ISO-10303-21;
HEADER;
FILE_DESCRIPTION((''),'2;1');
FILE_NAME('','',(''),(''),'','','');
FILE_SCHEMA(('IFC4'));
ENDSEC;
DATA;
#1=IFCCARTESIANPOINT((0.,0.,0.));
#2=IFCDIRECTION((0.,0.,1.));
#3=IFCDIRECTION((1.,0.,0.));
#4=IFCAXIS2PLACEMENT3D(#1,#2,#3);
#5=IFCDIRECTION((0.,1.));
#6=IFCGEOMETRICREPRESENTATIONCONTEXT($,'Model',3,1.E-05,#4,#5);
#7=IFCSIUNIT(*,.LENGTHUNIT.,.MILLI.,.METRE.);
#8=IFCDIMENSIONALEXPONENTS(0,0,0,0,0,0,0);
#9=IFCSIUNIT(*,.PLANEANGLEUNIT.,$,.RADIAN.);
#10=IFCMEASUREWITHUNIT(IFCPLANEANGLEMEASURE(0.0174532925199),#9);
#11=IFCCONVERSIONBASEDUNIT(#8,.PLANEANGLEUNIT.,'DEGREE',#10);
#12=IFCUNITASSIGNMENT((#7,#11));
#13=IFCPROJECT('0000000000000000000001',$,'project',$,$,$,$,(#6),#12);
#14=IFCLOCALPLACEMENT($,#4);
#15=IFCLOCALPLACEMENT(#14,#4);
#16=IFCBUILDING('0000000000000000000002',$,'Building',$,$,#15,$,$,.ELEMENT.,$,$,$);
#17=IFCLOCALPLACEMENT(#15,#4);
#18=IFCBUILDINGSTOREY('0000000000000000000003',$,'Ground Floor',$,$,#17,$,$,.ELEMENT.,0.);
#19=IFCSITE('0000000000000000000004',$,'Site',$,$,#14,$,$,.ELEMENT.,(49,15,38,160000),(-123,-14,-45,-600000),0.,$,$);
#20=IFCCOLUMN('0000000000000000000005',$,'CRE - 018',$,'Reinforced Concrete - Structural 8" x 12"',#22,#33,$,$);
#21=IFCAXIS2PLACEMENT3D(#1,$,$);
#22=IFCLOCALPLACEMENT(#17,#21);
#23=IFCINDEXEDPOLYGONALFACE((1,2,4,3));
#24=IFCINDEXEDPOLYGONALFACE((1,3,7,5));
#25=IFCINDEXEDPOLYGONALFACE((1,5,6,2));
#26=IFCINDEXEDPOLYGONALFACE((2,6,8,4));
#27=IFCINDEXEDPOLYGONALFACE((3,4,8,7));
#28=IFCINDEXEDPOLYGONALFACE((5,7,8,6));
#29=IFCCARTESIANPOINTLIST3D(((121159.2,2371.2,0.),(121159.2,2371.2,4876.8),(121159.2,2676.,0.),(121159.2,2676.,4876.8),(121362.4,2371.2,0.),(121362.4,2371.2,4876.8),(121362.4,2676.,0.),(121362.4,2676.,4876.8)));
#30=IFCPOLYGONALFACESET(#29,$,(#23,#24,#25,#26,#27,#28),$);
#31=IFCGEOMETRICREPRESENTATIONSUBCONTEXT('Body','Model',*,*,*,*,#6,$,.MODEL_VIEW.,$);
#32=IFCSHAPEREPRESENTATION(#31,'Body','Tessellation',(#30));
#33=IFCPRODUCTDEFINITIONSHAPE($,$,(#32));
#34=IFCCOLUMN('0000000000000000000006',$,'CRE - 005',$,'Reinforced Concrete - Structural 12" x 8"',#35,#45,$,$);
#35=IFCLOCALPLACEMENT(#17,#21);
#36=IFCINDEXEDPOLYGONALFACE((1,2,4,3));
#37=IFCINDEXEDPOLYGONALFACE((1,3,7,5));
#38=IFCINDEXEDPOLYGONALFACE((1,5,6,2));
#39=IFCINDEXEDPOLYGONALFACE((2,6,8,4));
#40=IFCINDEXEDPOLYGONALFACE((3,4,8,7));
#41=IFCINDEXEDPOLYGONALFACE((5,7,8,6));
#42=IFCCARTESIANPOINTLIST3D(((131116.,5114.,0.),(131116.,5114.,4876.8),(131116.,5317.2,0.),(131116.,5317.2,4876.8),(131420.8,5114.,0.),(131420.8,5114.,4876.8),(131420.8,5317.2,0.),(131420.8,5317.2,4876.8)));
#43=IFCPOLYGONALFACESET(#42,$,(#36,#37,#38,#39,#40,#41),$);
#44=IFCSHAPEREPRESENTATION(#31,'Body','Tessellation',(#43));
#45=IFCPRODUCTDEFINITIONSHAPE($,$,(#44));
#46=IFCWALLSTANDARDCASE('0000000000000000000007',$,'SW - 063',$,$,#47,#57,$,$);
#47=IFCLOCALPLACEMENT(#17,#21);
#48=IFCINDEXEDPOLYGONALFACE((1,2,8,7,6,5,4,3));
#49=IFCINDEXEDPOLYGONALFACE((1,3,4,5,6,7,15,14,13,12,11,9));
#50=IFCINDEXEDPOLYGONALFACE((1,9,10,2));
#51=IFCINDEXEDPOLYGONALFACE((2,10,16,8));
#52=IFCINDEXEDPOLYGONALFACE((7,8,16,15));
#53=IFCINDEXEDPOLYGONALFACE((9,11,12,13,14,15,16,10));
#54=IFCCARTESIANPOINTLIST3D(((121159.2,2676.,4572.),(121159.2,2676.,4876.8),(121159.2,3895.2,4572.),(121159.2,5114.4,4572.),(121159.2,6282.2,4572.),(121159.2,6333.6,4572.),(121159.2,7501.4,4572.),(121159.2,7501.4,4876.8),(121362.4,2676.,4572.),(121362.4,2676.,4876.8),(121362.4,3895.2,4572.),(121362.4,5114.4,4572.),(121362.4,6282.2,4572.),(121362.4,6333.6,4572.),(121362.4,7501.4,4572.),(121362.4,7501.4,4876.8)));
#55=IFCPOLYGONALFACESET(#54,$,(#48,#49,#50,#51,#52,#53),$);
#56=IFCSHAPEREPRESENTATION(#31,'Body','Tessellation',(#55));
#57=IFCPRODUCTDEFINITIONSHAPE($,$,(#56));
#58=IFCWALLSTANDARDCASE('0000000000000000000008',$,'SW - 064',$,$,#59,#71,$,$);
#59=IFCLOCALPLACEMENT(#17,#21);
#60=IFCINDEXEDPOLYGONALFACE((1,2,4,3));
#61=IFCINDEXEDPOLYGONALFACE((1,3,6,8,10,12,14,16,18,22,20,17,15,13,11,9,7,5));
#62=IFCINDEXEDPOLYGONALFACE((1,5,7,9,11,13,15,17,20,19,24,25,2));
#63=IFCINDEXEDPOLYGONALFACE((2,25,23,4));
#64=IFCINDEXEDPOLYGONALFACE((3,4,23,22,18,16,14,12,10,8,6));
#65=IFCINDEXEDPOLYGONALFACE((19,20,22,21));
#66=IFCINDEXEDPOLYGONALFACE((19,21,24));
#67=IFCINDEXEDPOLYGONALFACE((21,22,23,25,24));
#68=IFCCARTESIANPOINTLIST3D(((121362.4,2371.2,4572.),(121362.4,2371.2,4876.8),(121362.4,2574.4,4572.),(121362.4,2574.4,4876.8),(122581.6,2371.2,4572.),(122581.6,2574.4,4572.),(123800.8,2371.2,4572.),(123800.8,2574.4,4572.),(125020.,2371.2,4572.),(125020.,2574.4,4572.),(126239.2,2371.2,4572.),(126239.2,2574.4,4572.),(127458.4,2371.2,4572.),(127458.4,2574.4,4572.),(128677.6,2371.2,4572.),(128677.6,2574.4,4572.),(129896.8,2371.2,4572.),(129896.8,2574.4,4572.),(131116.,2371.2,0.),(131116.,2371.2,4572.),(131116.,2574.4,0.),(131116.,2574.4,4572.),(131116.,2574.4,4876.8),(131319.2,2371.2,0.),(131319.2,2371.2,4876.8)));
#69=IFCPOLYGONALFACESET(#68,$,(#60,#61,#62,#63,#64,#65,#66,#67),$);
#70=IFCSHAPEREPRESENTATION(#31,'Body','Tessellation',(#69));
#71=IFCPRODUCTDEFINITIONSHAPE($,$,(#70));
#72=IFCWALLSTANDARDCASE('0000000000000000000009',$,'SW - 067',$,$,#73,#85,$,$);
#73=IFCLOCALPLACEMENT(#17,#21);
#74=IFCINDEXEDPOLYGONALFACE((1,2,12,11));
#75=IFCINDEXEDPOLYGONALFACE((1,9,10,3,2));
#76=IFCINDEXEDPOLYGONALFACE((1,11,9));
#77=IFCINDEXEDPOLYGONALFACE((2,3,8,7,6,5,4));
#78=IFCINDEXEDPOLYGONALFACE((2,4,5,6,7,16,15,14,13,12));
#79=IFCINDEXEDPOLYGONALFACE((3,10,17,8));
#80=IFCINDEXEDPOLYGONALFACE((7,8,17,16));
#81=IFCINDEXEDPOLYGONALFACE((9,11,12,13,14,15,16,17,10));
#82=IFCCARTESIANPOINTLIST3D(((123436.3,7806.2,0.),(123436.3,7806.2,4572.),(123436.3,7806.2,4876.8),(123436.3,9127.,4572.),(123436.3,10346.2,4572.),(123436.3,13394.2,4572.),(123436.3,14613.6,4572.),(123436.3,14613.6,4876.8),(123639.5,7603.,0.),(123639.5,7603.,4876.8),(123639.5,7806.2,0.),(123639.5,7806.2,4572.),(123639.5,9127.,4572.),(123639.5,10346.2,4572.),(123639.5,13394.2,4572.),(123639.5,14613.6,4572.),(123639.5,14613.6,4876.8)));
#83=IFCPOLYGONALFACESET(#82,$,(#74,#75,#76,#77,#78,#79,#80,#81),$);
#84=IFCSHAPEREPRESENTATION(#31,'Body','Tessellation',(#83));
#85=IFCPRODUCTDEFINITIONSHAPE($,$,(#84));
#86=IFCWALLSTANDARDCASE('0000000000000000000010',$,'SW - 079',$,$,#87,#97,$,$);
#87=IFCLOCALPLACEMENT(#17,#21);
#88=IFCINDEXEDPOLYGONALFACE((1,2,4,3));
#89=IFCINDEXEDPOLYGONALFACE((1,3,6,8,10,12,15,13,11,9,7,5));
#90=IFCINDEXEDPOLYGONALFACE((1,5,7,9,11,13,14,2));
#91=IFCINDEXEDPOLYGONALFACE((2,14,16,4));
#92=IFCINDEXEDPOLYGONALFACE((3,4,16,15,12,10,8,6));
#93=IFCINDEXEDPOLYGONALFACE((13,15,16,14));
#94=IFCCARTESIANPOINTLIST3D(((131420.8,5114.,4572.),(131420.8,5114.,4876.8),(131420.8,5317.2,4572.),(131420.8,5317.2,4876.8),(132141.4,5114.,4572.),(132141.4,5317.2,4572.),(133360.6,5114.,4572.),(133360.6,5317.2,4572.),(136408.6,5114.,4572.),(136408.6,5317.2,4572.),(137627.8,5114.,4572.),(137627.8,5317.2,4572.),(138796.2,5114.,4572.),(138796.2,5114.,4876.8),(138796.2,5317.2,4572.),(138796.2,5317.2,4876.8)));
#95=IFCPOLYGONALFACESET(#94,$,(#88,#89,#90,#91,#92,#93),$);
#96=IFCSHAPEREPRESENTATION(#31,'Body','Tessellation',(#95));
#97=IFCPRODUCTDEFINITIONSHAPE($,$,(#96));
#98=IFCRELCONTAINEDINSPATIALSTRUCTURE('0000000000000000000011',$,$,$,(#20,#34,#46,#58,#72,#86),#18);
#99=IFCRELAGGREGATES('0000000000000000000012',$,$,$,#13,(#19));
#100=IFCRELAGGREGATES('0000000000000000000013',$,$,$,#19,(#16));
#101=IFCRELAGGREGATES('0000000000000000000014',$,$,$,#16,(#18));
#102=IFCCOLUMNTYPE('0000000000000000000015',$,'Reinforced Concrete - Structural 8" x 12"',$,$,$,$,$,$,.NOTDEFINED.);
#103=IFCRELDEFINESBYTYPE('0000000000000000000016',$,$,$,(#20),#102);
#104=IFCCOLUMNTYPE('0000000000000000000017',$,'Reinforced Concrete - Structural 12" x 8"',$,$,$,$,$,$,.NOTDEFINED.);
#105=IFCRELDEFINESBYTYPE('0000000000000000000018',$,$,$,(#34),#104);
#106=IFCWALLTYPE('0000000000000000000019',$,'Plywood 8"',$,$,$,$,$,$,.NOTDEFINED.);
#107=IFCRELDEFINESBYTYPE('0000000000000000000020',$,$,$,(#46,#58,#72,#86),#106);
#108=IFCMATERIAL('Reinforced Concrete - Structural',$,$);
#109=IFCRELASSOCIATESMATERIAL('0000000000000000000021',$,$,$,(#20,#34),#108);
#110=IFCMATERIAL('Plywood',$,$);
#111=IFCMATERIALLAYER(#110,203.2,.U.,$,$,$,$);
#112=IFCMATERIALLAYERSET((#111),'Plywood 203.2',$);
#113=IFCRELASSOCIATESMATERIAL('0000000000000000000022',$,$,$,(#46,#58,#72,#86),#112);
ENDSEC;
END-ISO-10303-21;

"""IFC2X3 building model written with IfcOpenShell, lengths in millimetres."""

from ifc_helpers import new_model, entity, si_unit, converted_unit, direction, frame, origin_with_axes, origin_2d_with_axis, place, context, subcontext, project, spatial, polyline, rectangle, outline, extrude, material, layer, layer_set, layer_usage, type_object, element, save


model = new_model("IFC2X3")

# Units and contexts
model_context = context("Model", 3, precision=1e-05, world=origin_with_axes(), true_north=direction((0.0, 1.0)))
body_context = subcontext(model_context, "Body", "Model", "MODEL_VIEW")
ifc_project = project(units=[si_unit("LENGTHUNIT", "METRE", prefix="MILLI"), converted_unit("PLANEANGLEUNIT", "DEGREE", entity("IfcPlaneAngleMeasure", 0.0174532925199), si_unit("PLANEANGLEUNIT", "RADIAN"), dimensions=[0, 0, 0, 0, 0, 0, 0])], contexts=[model_context])

# Site, building, storey
site_placement = place(None, origin_with_axes())
site = spatial("IfcSite", under=ifc_project, at=site_placement, Name="Site", CompositionType="ELEMENT", RefLatitude=(49, 15, 38, 160000), RefLongitude=(-123, -14, -45, -600000), RefElevation=0.0)
building_placement = place(site_placement, origin_with_axes())
building = spatial("IfcBuilding", under=site, at=building_placement, Name="Building", CompositionType="ELEMENT")
storey_placement = place(building_placement, origin_with_axes())
storey = spatial("IfcBuildingStorey", under=building, at=storey_placement, Name="Ground Floor", CompositionType="ELEMENT", Elevation=0.0)

# Columns
ifc_material_1 = material(Name="Reinforced Concrete - Structural")
column_type_1 = type_object("IfcColumnType", Name="Reinforced Concrete - Structural 8\" x 12\"", PredefinedType="NOTDEFINED")
column_1_placement = place(storey_placement, frame((121260.8, 2523.6, 0.0), z_axis=(0.0, 0.0, 1.0), x_axis=(1.0, 0.0, 0.0)))
element("IfcColumn", 1, at=column_1_placement, inside=storey, type_object=column_type_1, material=ifc_material_1, Name="CRE - 018", ObjectType="Reinforced Concrete - Structural 8\" x 12\"", context=body_context, shape_type="SweptSolid", body=[
    extrude(rectangle(XDim=203.2, YDim=304.8, at=origin_2d_with_axis()), origin_with_axes(), (0.0, 0.0, 1.0), 4876.8),
])
column_type_2 = type_object("IfcColumnType", Name="Reinforced Concrete - Structural 12\" x 8\"", PredefinedType="NOTDEFINED")
column_2_placement = place(storey_placement, frame((131268.4, 5215.6, 0.0), z_axis=(0.0, 0.0, 1.0), x_axis=(1.0, 0.0, 0.0)))
element("IfcColumn", 2, at=column_2_placement, inside=storey, type_object=column_type_2, material=ifc_material_1, Name="CRE - 005", ObjectType="Reinforced Concrete - Structural 12\" x 8\"", context=body_context, shape_type="SweptSolid", body=[
    extrude(rectangle(XDim=304.8, YDim=203.2, at=origin_2d_with_axis()), origin_with_axes(), (0.0, 0.0, 1.0), 4876.8),
])

# Walls, openings
ifc_material_2 = material(Name="Plywood")
ifc_layer = layer(ifc_material_2, 203.2, ventilated="UNKNOWN")
ifc_layer_set = layer_set([ifc_layer], Name="Plywood 203.2")
ifc_layer_usage_1 = layer_usage(ifc_layer_set, "AXIS2", "NEGATIVE", 0.0)
wall_type = type_object("IfcWallType", Name="Plywood 8\"", PredefinedType="NOTDEFINED")
wall_1_placement = place(storey_placement, frame((121362.4, 7501.4, 0.0), z_axis=(0.0, 0.0, 1.0), x_axis=(0.0, -1.0, 0.0)))
wall_1 = element("IfcWallStandardCase", 3, at=wall_1_placement, inside=storey, type_object=wall_type, material=ifc_layer_usage_1, Name="SW - 063", context=body_context, shape_type="SweptSolid", body=[
    extrude(outline(polyline([(0.0, -203.2), (4825.5, -203.2), (4825.5, 0.0), (0.0, 0.0), (0.0, -203.2)])), origin_with_axes(), (0.0, 0.0, 1.0), 4876.8),
])
opening_1_placement = place(wall_1_placement, frame((609.6, 0.0, 0.0), z_axis=(0.0, 0.0, 1.0), x_axis=(1.0, 0.0, 0.0)))
element("IfcOpeningElement", 4, at=opening_1_placement, cuts=wall_1, context=body_context, shape_type="SweptSolid", body=[
    extrude(rectangle(XDim=1219.2, YDim=4572.0, at=origin_2d_with_axis()), frame((0.0, 203.2, 2286.0), z_axis=(0.0, 1.0, 0.0), x_axis=(1.0, 0.0, 0.0)), (0.0, 0.0, -1.0), 609.6),
])
opening_2_placement = place(wall_1_placement, frame((1777.5, 0.0, 0.0), z_axis=(0.0, 0.0, 1.0), x_axis=(1.0, 0.0, 0.0)))
element("IfcOpeningElement", 5, at=opening_2_placement, cuts=wall_1, context=body_context, shape_type="SweptSolid", body=[
    extrude(rectangle(XDim=1219.2, YDim=4572.0, at=origin_2d_with_axis()), frame((0.0, 203.2, 2286.0), z_axis=(0.0, -1.0, 0.0), x_axis=(-1.0, 0.0, 0.0)), (0.0, 0.0, 1.0), 609.6),
])
opening_3_placement = place(wall_1_placement, frame((2996.7, 0.0, 0.0), z_axis=(0.0, 0.0, 1.0), x_axis=(1.0, 0.0, 0.0)))
element("IfcOpeningElement", 6, at=opening_3_placement, cuts=wall_1, context=body_context, shape_type="SweptSolid", body=[
    extrude(rectangle(XDim=1219.2, YDim=4572.0, at=origin_2d_with_axis()), frame((0.0, 203.2, 2286.0), z_axis=(0.0, -1.0, 0.0), x_axis=(-1.0, 0.0, 0.0)), (0.0, 0.0, 1.0), 609.6),
])
opening_4_placement = place(wall_1_placement, frame((4215.9, 0.0, 0.0), z_axis=(0.0, 0.0, 1.0), x_axis=(1.0, 0.0, 0.0)))
element("IfcOpeningElement", 7, at=opening_4_placement, cuts=wall_1, context=body_context, shape_type="SweptSolid", body=[
    extrude(rectangle(XDim=1219.2, YDim=4572.0, at=origin_2d_with_axis()), frame((0.0, 203.2, 2286.0), z_axis=(0.0, -1.0, 0.0), x_axis=(-1.0, 0.0, 0.0)), (0.0, 0.0, 1.0), 609.6),
])
ifc_layer_usage_2 = layer_usage(ifc_layer_set, "AXIS2", "NEGATIVE", 0.0)
wall_2_placement = place(storey_placement, frame((121362.4, 2574.4, 0.0), z_axis=(0.0, 0.0, 1.0), x_axis=(1.0, 0.0, 0.0)))
wall_2 = element("IfcWallStandardCase", 8, at=wall_2_placement, inside=storey, type_object=wall_type, material=ifc_layer_usage_2, Name="SW - 064", context=body_context, shape_type="SweptSolid", body=[
    extrude(outline(polyline([(0.0, -203.2), (9956.8, -203.2), (9753.6, 0.0), (0.0, 0.0), (0.0, -203.2)])), origin_with_axes(), (0.0, 0.0, 1.0), 4876.8),
])
opening_5_placement = place(wall_2_placement, frame((9144.0, 0.0, 0.0), z_axis=(0.0, 0.0, 1.0), x_axis=(1.0, 0.0, 0.0)))
element("IfcOpeningElement", 9, at=opening_5_placement, cuts=wall_2, context=body_context, shape_type="SweptSolid", body=[
    extrude(rectangle(XDim=1219.2, YDim=4572.0, at=origin_2d_with_axis()), frame((0.0, 203.2, 2286.0), z_axis=(0.0, -1.0, 0.0), x_axis=(-1.0, 0.0, 0.0)), (0.0, 0.0, 1.0), 609.6),
])
opening_6_placement = place(wall_2_placement, frame((7924.8, 0.0, 0.0), z_axis=(0.0, 0.0, 1.0), x_axis=(1.0, 0.0, 0.0)))
element("IfcOpeningElement", 10, at=opening_6_placement, cuts=wall_2, context=body_context, shape_type="SweptSolid", body=[
    extrude(rectangle(XDim=1219.2, YDim=4572.0, at=origin_2d_with_axis()), frame((0.0, 203.2, 2286.0), z_axis=(0.0, -1.0, 0.0), x_axis=(-1.0, 0.0, 0.0)), (0.0, 0.0, 1.0), 609.6),
])
opening_7_placement = place(wall_2_placement, frame((6705.6, 0.0, 0.0), z_axis=(0.0, 0.0, 1.0), x_axis=(1.0, 0.0, 0.0)))
element("IfcOpeningElement", 11, at=opening_7_placement, cuts=wall_2, context=body_context, shape_type="SweptSolid", body=[
    extrude(rectangle(XDim=1219.2, YDim=4572.0, at=origin_2d_with_axis()), frame((0.0, 203.2, 2286.0), z_axis=(0.0, -1.0, 0.0), x_axis=(-1.0, 0.0, 0.0)), (0.0, 0.0, 1.0), 609.6),
])
opening_8_placement = place(wall_2_placement, frame((5486.4, 0.0, 0.0), z_axis=(0.0, 0.0, 1.0), x_axis=(1.0, 0.0, 0.0)))
element("IfcOpeningElement", 12, at=opening_8_placement, cuts=wall_2, context=body_context, shape_type="SweptSolid", body=[
    extrude(rectangle(XDim=1219.2, YDim=4572.0, at=origin_2d_with_axis()), frame((0.0, 203.2, 2286.0), z_axis=(0.0, 1.0, 0.0), x_axis=(1.0, 0.0, 0.0)), (0.0, 0.0, -1.0), 609.6),
])
opening_9_placement = place(wall_2_placement, frame((4267.2, 0.0, 0.0), z_axis=(0.0, 0.0, 1.0), x_axis=(1.0, 0.0, 0.0)))
element("IfcOpeningElement", 13, at=opening_9_placement, cuts=wall_2, context=body_context, shape_type="SweptSolid", body=[
    extrude(rectangle(XDim=1219.2, YDim=4572.0, at=origin_2d_with_axis()), frame((0.0, 203.2, 2286.0), z_axis=(0.0, -1.0, 0.0), x_axis=(-1.0, 0.0, 0.0)), (0.0, 0.0, 1.0), 609.6),
])
opening_10_placement = place(wall_2_placement, frame((3048.0, 0.0, 0.0), z_axis=(0.0, 0.0, 1.0), x_axis=(1.0, 0.0, 0.0)))
element("IfcOpeningElement", 14, at=opening_10_placement, cuts=wall_2, context=body_context, shape_type="SweptSolid", body=[
    extrude(rectangle(XDim=1219.2, YDim=4572.0, at=origin_2d_with_axis()), frame((0.0, 203.2, 2286.0), z_axis=(0.0, -1.0, 0.0), x_axis=(-1.0, 0.0, 0.0)), (0.0, 0.0, 1.0), 609.6),
])
opening_11_placement = place(wall_2_placement, frame((1828.8, 0.0, 0.0), z_axis=(0.0, 0.0, 1.0), x_axis=(1.0, 0.0, 0.0)))
element("IfcOpeningElement", 15, at=opening_11_placement, cuts=wall_2, context=body_context, shape_type="SweptSolid", body=[
    extrude(rectangle(XDim=1219.2, YDim=4572.0, at=origin_2d_with_axis()), frame((0.0, 203.2, 2286.0), z_axis=(0.0, -1.0, 0.0), x_axis=(-1.0, 0.0, 0.0)), (0.0, 0.0, 1.0), 609.6),
])
opening_12_placement = place(wall_2_placement, frame((609.6, 0.0, 0.0), z_axis=(0.0, 0.0, 1.0), x_axis=(1.0, 0.0, 0.0)))
element("IfcOpeningElement", 16, at=opening_12_placement, cuts=wall_2, context=body_context, shape_type="SweptSolid", body=[
    extrude(rectangle(XDim=1219.2, YDim=4572.0, at=origin_2d_with_axis()), frame((0.0, 203.2, 2286.0), z_axis=(0.0, 1.0, 0.0), x_axis=(1.0, 0.0, 0.0)), (0.0, 0.0, -1.0), 609.6),
])
ifc_layer_usage_3 = layer_usage(ifc_layer_set, "AXIS2", "POSITIVE", 0.0)
wall_3_placement = place(storey_placement, frame((123639.5, 7603.0, 0.0), z_axis=(0.0, 0.0, 1.0), x_axis=(0.0, 1.0, 0.0)))
wall_3 = element("IfcWallStandardCase", 17, at=wall_3_placement, inside=storey, type_object=wall_type, material=ifc_layer_usage_3, Name="SW - 067", context=body_context, shape_type="SweptSolid", body=[
    extrude(outline(polyline([(0.0, 0.0), (7010.6, 0.0), (7010.6, 203.2), (203.2, 203.2), (0.0, 0.0)])), origin_with_axes(), (0.0, 0.0, 1.0), 4876.8),
])
opening_13_placement = place(wall_3_placement, frame((6400.9, 0.0, 0.0), z_axis=(0.0, 0.0, 1.0), x_axis=(1.0, 0.0, 0.0)))
element("IfcOpeningElement", 18, at=opening_13_placement, cuts=wall_3, context=body_context, shape_type="SweptSolid", body=[
    extrude(rectangle(XDim=1219.4, YDim=4572.0, at=origin_2d_with_axis()), frame((0.0, -203.2, 2286.0), z_axis=(0.0, -1.0, 0.0), x_axis=(-1.0, 0.0, 0.0)), (0.0, 0.0, -1.0), 609.6),
])
opening_14_placement = place(wall_3_placement, frame((863.6, 0.0, 0.0), z_axis=(0.0, 0.0, 1.0), x_axis=(1.0, 0.0, 0.0)))
element("IfcOpeningElement", 19, at=opening_14_placement, cuts=wall_3, context=body_context, shape_type="SweptSolid", body=[
    extrude(rectangle(XDim=1320.8, YDim=4572.0, at=origin_2d_with_axis()), frame((0.0, -203.2, 2286.0), z_axis=(0.0, -1.0, 0.0), x_axis=(-1.0, 0.0, 0.0)), (0.0, 0.0, -1.0), 609.6),
])
opening_15_placement = place(wall_3_placement, frame((2133.6, 0.0, 0.0), z_axis=(0.0, 0.0, 1.0), x_axis=(1.0, 0.0, 0.0)))
element("IfcOpeningElement", 20, at=opening_15_placement, cuts=wall_3, context=body_context, shape_type="SweptSolid", body=[
    extrude(rectangle(XDim=1219.2, YDim=4572.0, at=origin_2d_with_axis()), frame((0.0, -203.2, 2286.0), z_axis=(0.0, -1.0, 0.0), x_axis=(-1.0, 0.0, 0.0)), (0.0, 0.0, -1.0), 609.6),
])
opening_16_placement = place(wall_3_placement, frame((4267.2, 0.0, 0.0), z_axis=(0.0, 0.0, 1.0), x_axis=(1.0, 0.0, 0.0)))
element("IfcOpeningElement", 21, at=opening_16_placement, cuts=wall_3, context=body_context, shape_type="SweptSolid", body=[
    extrude(rectangle(XDim=3048.0, YDim=4572.0, at=origin_2d_with_axis()), frame((0.0, -203.2, 2286.0), z_axis=(0.0, -1.0, 0.0), x_axis=(-1.0, 0.0, 0.0)), (0.0, 0.0, -1.0), 609.6),
])
ifc_layer_usage_4 = layer_usage(ifc_layer_set, "AXIS2", "NEGATIVE", 0.0)
wall_4_placement = place(storey_placement, frame((131420.8, 5317.2, 0.0), z_axis=(0.0, 0.0, 1.0), x_axis=(1.0, 0.0, 0.0)))
wall_4 = element("IfcWallStandardCase", 22, at=wall_4_placement, inside=storey, type_object=wall_type, material=ifc_layer_usage_4, Name="SW - 079", context=body_context, shape_type="SweptSolid", body=[
    extrude(outline(polyline([(0.0, -203.2), (7375.4, -203.2), (7375.4, 0.0), (0.0, 0.0), (0.0, -203.2)])), origin_with_axes(), (0.0, 0.0, 1.0), 4876.8),
])
opening_17_placement = place(wall_4_placement, frame((360.3, 0.0, 0.0), z_axis=(0.0, 0.0, 1.0), x_axis=(1.0, 0.0, 0.0)))
element("IfcOpeningElement", 23, at=opening_17_placement, cuts=wall_4, context=body_context, shape_type="SweptSolid", body=[
    extrude(rectangle(XDim=720.6, YDim=4572.0, at=origin_2d_with_axis()), frame((0.0, 203.2, 2286.0), z_axis=(0.0, 1.0, 0.0), x_axis=(1.0, 0.0, 0.0)), (0.0, 0.0, -1.0), 609.6),
])
opening_18_placement = place(wall_4_placement, frame((1330.2, 0.0, 0.0), z_axis=(0.0, 0.0, 1.0), x_axis=(1.0, 0.0, 0.0)))
element("IfcOpeningElement", 24, at=opening_18_placement, cuts=wall_4, context=body_context, shape_type="SweptSolid", body=[
    extrude(rectangle(XDim=1219.2, YDim=4572.0, at=origin_2d_with_axis()), frame((0.0, 203.2, 2286.0), z_axis=(0.0, -1.0, 0.0), x_axis=(-1.0, 0.0, 0.0)), (0.0, 0.0, 1.0), 609.6),
])
opening_19_placement = place(wall_4_placement, frame((5597.4, 0.0, 0.0), z_axis=(0.0, 0.0, 1.0), x_axis=(1.0, 0.0, 0.0)))
element("IfcOpeningElement", 25, at=opening_19_placement, cuts=wall_4, context=body_context, shape_type="SweptSolid", body=[
    extrude(rectangle(XDim=1219.2, YDim=4572.0, at=origin_2d_with_axis()), frame((0.0, 203.2, 2286.0), z_axis=(0.0, 1.0, 0.0), x_axis=(1.0, 0.0, 0.0)), (0.0, 0.0, -1.0), 609.6),
])
opening_20_placement = place(wall_4_placement, frame((6791.2, 0.0, 0.0), z_axis=(0.0, 0.0, 1.0), x_axis=(1.0, 0.0, 0.0)))
element("IfcOpeningElement", 26, at=opening_20_placement, cuts=wall_4, context=body_context, shape_type="SweptSolid", body=[
    extrude(rectangle(XDim=1168.4, YDim=4572.0, at=origin_2d_with_axis()), frame((0.0, 203.2, 2286.0), z_axis=(0.0, -1.0, 0.0), x_axis=(-1.0, 0.0, 0.0)), (0.0, 0.0, 1.0), 609.6),
])
opening_21_placement = place(wall_4_placement, frame((3463.8, 0.0, 0.0), z_axis=(0.0, 0.0, 1.0), x_axis=(1.0, 0.0, 0.0)))
element("IfcOpeningElement", 27, at=opening_21_placement, cuts=wall_4, context=body_context, shape_type="SweptSolid", body=[
    extrude(rectangle(XDim=3048.0, YDim=4572.0, at=origin_2d_with_axis()), frame((0.0, 203.2, 2286.0), z_axis=(0.0, -1.0, 0.0), x_axis=(-1.0, 0.0, 0.0)), (0.0, 0.0, 1.0), 609.6),
])

save(model, "model.ifc")
